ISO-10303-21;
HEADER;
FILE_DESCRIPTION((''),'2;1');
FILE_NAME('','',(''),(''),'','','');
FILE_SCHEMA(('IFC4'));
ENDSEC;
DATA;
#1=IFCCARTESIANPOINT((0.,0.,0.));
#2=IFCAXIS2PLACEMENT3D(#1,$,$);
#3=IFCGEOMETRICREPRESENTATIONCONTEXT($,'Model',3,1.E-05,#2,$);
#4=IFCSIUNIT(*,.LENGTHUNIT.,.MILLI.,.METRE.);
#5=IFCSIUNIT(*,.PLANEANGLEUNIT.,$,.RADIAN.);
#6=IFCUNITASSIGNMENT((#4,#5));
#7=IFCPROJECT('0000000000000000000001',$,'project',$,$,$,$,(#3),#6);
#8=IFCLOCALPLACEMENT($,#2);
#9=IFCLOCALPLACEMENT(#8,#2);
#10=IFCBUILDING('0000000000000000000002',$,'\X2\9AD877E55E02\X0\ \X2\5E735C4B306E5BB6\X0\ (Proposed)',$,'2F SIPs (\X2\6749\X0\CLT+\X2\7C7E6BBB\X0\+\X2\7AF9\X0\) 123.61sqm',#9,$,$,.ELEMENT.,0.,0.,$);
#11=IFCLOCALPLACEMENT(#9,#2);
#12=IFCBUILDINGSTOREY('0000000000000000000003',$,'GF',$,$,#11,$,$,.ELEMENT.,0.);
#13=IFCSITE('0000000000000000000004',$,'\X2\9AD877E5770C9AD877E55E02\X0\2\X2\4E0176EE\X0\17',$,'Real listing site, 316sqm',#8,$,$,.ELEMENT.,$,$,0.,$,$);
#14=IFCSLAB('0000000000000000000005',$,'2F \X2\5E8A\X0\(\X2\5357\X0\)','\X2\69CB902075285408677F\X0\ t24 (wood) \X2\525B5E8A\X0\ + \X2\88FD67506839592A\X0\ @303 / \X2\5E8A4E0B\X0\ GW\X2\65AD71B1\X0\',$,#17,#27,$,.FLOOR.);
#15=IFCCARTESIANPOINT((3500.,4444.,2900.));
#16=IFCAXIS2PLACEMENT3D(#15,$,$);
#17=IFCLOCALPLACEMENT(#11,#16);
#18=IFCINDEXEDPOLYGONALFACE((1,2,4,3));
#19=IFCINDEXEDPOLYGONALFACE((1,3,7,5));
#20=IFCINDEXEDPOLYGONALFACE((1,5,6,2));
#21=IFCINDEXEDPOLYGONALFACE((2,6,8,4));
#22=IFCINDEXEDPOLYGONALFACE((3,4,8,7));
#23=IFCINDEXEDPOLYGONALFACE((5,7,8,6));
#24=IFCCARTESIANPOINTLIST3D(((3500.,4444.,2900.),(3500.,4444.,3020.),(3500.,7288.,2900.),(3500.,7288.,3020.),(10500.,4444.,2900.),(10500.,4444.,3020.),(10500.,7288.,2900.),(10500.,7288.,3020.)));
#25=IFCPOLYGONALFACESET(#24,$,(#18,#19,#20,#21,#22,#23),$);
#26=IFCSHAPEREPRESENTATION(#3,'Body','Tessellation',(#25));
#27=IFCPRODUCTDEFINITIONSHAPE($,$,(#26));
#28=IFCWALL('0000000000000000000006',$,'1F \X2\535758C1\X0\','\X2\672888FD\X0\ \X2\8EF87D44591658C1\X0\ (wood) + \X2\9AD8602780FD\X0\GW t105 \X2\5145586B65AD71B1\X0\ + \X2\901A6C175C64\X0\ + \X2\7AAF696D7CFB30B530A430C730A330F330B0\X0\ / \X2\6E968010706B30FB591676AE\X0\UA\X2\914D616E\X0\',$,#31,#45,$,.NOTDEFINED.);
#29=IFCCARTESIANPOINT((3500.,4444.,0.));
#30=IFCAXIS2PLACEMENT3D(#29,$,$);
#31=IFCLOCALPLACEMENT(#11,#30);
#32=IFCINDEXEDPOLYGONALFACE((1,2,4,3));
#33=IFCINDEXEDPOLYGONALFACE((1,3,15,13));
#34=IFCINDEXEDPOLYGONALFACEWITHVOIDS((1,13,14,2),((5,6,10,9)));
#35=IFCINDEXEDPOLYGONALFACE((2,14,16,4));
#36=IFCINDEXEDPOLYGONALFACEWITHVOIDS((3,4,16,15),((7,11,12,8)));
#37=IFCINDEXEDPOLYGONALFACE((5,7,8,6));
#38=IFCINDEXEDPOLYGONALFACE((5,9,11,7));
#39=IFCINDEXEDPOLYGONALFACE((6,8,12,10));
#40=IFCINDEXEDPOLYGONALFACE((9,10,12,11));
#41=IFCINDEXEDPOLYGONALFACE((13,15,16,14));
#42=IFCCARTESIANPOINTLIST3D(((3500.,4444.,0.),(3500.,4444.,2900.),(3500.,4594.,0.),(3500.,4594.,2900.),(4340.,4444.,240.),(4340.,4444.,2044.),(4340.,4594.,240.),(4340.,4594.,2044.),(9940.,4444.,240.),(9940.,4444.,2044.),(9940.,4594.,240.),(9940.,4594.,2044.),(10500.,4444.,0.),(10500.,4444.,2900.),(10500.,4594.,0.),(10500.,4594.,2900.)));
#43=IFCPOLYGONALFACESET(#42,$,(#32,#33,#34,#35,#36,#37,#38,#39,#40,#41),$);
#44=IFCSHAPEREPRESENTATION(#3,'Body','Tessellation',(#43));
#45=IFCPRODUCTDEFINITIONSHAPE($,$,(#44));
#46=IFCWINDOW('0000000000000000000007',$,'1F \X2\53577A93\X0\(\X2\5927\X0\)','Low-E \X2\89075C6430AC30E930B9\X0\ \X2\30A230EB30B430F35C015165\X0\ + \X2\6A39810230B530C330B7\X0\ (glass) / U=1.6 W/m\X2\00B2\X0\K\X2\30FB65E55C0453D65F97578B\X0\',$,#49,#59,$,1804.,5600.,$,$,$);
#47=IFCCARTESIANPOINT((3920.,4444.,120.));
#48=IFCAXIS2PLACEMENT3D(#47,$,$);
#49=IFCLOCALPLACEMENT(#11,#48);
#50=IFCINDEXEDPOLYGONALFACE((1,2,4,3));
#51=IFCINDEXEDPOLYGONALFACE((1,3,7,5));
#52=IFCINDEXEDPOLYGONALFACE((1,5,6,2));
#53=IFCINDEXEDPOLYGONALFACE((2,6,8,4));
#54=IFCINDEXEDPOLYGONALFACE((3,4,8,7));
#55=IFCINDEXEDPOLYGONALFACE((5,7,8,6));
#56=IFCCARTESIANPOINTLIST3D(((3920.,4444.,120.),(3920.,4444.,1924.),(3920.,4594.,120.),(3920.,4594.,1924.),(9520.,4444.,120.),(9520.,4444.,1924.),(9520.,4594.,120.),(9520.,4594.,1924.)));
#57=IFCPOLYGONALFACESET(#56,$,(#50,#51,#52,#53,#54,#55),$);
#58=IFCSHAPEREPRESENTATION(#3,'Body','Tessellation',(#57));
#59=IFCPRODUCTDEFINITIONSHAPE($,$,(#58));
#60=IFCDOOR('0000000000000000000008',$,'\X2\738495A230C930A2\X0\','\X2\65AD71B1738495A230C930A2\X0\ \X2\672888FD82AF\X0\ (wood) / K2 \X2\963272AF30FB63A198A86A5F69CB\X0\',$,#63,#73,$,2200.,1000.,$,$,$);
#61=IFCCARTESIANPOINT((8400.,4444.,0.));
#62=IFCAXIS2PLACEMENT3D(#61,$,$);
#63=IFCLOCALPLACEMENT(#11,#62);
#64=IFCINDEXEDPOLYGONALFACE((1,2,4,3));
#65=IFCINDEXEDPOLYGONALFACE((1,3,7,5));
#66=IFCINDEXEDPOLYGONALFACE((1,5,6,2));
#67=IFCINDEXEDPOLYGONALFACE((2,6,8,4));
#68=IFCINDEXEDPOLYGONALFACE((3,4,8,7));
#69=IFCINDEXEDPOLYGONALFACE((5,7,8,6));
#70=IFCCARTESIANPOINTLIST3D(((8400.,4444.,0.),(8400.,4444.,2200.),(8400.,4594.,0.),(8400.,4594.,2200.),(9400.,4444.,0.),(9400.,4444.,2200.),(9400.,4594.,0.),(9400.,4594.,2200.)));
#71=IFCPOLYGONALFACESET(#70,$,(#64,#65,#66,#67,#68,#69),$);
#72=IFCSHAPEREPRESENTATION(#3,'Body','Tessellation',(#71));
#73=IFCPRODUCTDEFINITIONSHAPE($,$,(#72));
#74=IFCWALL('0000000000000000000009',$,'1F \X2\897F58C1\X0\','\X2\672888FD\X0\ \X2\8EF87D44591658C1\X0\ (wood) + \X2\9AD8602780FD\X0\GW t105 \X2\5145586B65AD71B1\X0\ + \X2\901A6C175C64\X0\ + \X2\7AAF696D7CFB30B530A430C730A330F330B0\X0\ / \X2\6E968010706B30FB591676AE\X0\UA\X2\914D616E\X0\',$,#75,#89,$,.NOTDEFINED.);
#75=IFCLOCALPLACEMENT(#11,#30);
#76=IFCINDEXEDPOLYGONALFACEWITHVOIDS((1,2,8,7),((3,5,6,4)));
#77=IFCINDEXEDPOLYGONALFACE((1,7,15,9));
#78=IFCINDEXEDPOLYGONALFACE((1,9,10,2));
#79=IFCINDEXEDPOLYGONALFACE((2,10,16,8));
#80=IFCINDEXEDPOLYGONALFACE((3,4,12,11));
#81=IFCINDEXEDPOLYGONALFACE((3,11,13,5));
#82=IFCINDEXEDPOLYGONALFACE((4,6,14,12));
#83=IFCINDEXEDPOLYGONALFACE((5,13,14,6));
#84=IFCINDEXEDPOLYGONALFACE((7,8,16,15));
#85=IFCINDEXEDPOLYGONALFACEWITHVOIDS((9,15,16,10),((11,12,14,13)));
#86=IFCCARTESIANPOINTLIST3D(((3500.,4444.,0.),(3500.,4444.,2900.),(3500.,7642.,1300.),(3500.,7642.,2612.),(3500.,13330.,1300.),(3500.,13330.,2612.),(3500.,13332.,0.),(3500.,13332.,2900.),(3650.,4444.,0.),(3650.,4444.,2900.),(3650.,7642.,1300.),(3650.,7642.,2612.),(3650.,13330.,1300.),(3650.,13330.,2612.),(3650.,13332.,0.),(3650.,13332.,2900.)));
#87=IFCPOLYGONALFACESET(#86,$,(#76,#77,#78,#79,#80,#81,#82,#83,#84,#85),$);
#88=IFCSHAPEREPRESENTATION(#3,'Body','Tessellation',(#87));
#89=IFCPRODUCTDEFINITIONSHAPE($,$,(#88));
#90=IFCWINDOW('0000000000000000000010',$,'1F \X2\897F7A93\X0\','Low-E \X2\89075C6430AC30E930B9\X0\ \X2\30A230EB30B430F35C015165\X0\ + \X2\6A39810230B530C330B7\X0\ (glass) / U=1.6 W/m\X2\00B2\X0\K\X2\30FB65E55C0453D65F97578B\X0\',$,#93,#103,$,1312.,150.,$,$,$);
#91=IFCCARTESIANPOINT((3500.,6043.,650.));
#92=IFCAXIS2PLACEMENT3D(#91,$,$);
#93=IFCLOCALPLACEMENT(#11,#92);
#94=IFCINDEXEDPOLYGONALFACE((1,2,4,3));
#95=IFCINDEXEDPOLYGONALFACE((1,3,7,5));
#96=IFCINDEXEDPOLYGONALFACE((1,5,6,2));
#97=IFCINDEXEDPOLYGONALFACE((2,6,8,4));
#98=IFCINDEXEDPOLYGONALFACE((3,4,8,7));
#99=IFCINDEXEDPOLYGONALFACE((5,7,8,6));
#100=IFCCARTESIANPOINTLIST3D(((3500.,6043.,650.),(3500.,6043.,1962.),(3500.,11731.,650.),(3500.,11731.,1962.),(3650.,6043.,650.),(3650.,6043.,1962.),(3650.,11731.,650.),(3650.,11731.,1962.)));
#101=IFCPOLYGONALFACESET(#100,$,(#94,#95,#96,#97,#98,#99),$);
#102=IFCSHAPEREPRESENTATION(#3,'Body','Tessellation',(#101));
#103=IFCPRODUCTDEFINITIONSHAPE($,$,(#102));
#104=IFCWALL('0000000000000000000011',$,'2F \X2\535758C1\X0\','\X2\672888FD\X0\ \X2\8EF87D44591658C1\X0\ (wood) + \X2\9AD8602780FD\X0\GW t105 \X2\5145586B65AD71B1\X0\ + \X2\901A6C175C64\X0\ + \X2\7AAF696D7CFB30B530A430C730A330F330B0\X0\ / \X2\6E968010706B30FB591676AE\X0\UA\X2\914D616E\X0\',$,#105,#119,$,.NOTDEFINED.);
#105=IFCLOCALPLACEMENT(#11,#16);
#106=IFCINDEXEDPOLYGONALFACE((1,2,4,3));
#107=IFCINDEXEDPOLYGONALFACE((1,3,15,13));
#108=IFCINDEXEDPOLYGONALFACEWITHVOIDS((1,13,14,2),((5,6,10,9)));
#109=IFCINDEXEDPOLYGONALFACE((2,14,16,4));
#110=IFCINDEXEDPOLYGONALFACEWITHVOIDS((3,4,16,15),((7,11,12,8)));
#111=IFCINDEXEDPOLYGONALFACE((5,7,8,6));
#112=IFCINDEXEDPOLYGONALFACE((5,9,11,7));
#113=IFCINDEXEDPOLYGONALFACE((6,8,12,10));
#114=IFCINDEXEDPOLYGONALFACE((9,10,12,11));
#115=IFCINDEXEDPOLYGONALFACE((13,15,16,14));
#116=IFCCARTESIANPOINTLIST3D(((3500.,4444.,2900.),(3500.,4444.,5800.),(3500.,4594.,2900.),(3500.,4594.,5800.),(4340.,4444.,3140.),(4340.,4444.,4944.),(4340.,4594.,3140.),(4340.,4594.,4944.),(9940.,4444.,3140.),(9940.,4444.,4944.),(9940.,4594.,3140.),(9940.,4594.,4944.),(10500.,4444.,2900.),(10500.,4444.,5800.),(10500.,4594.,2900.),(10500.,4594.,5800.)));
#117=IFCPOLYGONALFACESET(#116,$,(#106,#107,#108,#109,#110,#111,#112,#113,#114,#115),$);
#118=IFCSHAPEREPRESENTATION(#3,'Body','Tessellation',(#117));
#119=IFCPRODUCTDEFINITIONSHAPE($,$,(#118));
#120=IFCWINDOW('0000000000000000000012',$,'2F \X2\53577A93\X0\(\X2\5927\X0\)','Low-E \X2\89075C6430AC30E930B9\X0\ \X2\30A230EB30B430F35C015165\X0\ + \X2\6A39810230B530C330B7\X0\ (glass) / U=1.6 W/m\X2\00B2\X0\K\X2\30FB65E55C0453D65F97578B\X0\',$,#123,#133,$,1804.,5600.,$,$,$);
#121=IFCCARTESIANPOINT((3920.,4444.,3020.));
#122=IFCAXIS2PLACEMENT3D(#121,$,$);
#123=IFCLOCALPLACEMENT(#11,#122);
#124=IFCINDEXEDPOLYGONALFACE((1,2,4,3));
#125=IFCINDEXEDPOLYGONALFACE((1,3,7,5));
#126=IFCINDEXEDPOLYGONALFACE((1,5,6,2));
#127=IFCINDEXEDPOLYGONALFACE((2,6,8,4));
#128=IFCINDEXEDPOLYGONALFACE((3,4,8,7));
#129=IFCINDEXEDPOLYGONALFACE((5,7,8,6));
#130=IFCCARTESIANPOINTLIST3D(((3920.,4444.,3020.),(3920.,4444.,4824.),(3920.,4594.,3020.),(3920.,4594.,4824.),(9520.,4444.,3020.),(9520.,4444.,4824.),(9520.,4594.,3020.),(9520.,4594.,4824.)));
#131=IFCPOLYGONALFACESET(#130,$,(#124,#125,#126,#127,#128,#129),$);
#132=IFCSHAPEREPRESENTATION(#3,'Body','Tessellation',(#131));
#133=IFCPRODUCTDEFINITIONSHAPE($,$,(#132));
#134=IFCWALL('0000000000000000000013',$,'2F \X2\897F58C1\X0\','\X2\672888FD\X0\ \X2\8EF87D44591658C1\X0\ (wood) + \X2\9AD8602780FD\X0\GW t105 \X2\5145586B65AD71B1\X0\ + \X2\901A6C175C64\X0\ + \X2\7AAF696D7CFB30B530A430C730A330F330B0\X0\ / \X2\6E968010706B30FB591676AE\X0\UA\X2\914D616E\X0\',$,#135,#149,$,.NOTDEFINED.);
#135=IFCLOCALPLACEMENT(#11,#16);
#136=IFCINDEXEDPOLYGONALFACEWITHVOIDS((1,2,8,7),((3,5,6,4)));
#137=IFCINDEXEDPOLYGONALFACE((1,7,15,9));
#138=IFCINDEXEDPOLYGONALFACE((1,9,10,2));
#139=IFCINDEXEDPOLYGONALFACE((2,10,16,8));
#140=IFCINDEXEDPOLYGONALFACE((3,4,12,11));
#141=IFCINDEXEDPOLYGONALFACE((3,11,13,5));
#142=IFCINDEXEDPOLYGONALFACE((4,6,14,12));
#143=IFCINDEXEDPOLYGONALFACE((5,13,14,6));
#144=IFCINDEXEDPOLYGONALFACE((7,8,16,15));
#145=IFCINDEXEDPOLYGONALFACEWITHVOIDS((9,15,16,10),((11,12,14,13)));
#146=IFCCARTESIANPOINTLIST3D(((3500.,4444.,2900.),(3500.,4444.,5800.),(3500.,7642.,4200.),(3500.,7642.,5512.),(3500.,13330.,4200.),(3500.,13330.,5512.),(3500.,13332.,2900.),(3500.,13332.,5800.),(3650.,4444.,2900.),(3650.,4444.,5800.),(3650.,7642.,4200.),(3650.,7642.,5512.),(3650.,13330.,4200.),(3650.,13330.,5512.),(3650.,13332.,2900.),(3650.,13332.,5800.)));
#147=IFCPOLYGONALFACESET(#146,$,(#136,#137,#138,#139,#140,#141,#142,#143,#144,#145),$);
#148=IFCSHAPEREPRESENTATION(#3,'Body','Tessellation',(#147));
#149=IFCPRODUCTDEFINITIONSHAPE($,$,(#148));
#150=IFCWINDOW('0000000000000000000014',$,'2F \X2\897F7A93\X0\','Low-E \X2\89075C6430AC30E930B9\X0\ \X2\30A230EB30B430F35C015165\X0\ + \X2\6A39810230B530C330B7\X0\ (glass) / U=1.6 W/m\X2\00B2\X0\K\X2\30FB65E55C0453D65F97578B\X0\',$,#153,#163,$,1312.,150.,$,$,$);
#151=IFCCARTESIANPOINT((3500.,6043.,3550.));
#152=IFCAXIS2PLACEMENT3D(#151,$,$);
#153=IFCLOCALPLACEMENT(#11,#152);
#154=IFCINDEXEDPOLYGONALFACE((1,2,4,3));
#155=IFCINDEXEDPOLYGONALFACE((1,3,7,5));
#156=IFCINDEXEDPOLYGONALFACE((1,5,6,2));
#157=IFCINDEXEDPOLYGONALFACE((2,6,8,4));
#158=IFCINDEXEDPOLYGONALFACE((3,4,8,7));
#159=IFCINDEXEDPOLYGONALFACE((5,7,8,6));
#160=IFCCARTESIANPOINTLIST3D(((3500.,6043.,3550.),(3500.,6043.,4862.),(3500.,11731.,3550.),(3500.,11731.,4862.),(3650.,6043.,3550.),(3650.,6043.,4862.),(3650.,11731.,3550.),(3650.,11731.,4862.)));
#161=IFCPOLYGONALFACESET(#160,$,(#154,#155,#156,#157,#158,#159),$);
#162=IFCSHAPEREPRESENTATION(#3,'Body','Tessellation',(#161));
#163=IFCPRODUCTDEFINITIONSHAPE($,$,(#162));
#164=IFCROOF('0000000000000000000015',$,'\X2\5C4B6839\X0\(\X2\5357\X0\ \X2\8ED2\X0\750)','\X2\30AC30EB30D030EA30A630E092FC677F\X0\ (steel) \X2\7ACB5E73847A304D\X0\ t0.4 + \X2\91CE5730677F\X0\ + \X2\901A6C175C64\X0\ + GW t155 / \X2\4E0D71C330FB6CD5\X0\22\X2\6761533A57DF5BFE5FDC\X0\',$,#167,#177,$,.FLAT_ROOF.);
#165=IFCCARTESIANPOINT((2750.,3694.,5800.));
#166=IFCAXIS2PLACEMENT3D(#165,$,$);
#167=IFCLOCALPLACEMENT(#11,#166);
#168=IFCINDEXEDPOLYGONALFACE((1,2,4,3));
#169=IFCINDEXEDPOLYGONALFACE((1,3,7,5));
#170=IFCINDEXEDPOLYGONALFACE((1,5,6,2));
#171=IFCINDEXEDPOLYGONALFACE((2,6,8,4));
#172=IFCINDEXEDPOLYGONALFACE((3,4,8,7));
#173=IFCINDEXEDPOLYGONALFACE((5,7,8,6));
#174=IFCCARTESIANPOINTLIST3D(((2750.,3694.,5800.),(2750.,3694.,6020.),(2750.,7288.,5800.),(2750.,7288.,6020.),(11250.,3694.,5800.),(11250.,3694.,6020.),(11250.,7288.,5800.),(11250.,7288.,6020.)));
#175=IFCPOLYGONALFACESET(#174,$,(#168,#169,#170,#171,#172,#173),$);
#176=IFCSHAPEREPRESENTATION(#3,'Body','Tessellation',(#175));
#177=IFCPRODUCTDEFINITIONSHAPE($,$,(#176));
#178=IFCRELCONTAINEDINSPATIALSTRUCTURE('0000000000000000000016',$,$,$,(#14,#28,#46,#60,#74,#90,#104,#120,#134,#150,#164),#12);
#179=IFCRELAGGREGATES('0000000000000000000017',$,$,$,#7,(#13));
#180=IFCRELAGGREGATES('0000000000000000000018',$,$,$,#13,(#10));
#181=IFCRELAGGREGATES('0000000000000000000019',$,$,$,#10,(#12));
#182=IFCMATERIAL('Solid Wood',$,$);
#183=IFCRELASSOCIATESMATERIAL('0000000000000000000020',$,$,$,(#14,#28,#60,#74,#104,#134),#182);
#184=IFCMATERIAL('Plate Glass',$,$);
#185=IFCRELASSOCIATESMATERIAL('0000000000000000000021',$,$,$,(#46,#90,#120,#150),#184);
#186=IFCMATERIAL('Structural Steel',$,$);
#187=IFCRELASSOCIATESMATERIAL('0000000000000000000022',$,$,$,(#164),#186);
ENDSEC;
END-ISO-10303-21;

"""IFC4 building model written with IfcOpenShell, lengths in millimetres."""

from ifc_helpers import new_model, si_unit, frame, frame_2d, origin, place, context, project, spatial, rectangle, extrude, material, element, fill, save


model = new_model("IFC4")

# Units and contexts
model_context = context("Model", 3, precision=1e-05, world=origin())
ifc_project = project(units=[si_unit("LENGTHUNIT", "METRE", prefix="MILLI"), si_unit("PLANEANGLEUNIT", "RADIAN")], contexts=[model_context])

# Site, building, storey
site_placement = place(None, origin())
site = spatial("IfcSite", under=ifc_project, at=site_placement, Name="高知県高知市2丁目17", ObjectType="Real listing site, 316sqm", CompositionType="ELEMENT", RefElevation=0.0)
building_placement = place(site_placement, origin())
building = spatial("IfcBuilding", under=site, at=building_placement, Name="高知市 平屋の家 (Proposed)", ObjectType="2F SIPs (杉CLT+籾殻+竹) 123.61sqm", CompositionType="ELEMENT", ElevationOfRefHeight=0.0, ElevationOfTerrain=0.0)
storey_placement = place(building_placement, origin())
storey = spatial("IfcBuildingStorey", under=building, at=storey_placement, Name="GF", CompositionType="ELEMENT", Elevation=0.0)

# Slab
ifc_material_1 = material(Name="Solid Wood")
slab_1_placement = place(storey_placement, frame((3500.0, 4444.0, 2900.0)))
element("IfcSlab", 1, at=slab_1_placement, inside=storey, material=ifc_material_1, Name="2F 床(南)", Description="構造用合板 t24 (wood) 剛床 + 製材根太 @303 / 床下 GW断熱", PredefinedType="FLOOR", context=model_context, shape_type="SweptSolid", body=[
    extrude(rectangle(XDim=7000.0, YDim=2844.0, at=frame_2d((3500.0, 1422.0))), frame((3500.0, 4444.0, 2900.0)), (0.0, 0.0, 1.0), 120.0),
])

# Wall, openings, window, door
wall_1_placement = place(storey_placement, frame((3500.0, 4444.0, 0.0)))
wall_1 = element("IfcWall", 2, at=wall_1_placement, inside=storey, material=ifc_material_1, Name="1F 南壁", Description="木製 軸組外壁 (wood) + 高性能GW t105 充填断熱 + 通気層 + 窯業系サイディング / 準耐火・外皮UA配慮", PredefinedType="NOTDEFINED", context=model_context, shape_type="SweptSolid", body=[
    extrude(rectangle(XDim=7000.0, YDim=150.0, at=frame_2d((3500.0, 75.0))), frame((3500.0, 4444.0, 0.0)), (0.0, 0.0, 1.0), 2900.0),
])
opening_1_placement = place(storey_placement, frame((3920.0, 4444.0, 120.0)))
opening_1 = element("IfcOpeningElement", 3, at=opening_1_placement, cuts=wall_1, PredefinedType="NOTDEFINED", context=model_context, shape_type="SweptSolid", body=[
    extrude(rectangle(XDim=5600.0, YDim=150.0, at=frame_2d((2800.0, 75.0))), frame((3920.0, 4444.0, 120.0)), (0.0, 0.0, 1.0), 1804.0),
])
opening_2_placement = place(storey_placement, frame((8400.0, 4444.0, 0.0)))
opening_2 = element("IfcOpeningElement", 4, at=opening_2_placement, cuts=wall_1, PredefinedType="NOTDEFINED", context=model_context, shape_type="SweptSolid", body=[
    extrude(rectangle(XDim=1000.0, YDim=150.0, at=frame_2d((500.0, 75.0))), frame((8400.0, 4444.0, 0.0)), (0.0, 0.0, 1.0), 2200.0),
])
ifc_material_2 = material(Name="Plate Glass")
window_1_placement = place(storey_placement, frame((3920.0, 4444.0, 120.0)))
window_1 = element("IfcWindow", 5, at=window_1_placement, inside=storey, material=ifc_material_2, Name="1F 南窓(大)", Description="Low-E 複層ガラス アルゴン封入 + 樹脂サッシ (glass) / U=1.6 W/m²K・日射取得型", OverallHeight=1804.0, OverallWidth=5600.0, context=model_context, shape_type="SweptSolid", body=[
    extrude(rectangle(XDim=5600.0, YDim=150.0, at=frame_2d((2800.0, 75.0))), frame((3920.0, 4444.0, 120.0)), (0.0, 0.0, 1.0), 1804.0),
])
fill(opening_1, window_1)
door_placement = place(storey_placement, frame((8400.0, 4444.0, 0.0)))
door = element("IfcDoor", 6, at=door_placement, inside=storey, material=ifc_material_1, Name="玄関ドア", Description="断熱玄関ドア 木製芯 (wood) / K2 防犯・採風機構", OverallHeight=2200.0, OverallWidth=1000.0, context=model_context, shape_type="SweptSolid", body=[
    extrude(rectangle(XDim=1000.0, YDim=150.0, at=frame_2d((500.0, 75.0))), frame((8400.0, 4444.0, 0.0)), (0.0, 0.0, 1.0), 2200.0),
])
fill(opening_2, door)

# Walls, openings, windows
wall_2_placement = place(storey_placement, frame((3500.0, 4444.0, 0.0)))
wall_2 = element("IfcWall", 7, at=wall_2_placement, inside=storey, material=ifc_material_1, Name="1F 西壁", Description="木製 軸組外壁 (wood) + 高性能GW t105 充填断熱 + 通気層 + 窯業系サイディング / 準耐火・外皮UA配慮", PredefinedType="NOTDEFINED", context=model_context, shape_type="SweptSolid", body=[
    extrude(rectangle(XDim=150.0, YDim=8888.0, at=frame_2d((75.0, 4444.0))), frame((3500.0, 4444.0, 0.0)), (0.0, 0.0, 1.0), 2900.0),
])
opening_3_placement = place(storey_placement, frame((3500.0, 6043.0, 650.0)))
opening_3 = element("IfcOpeningElement", 8, at=opening_3_placement, cuts=wall_2, PredefinedType="NOTDEFINED", context=model_context, shape_type="SweptSolid", body=[
    extrude(rectangle(XDim=150.0, YDim=5688.0, at=frame_2d((75.0, 2844.0))), frame((3500.0, 6043.0, 650.0)), (0.0, 0.0, 1.0), 1312.0),
])
window_2_placement = place(storey_placement, frame((3500.0, 6043.0, 650.0)))
window_2 = element("IfcWindow", 9, at=window_2_placement, inside=storey, material=ifc_material_2, Name="1F 西窓", Description="Low-E 複層ガラス アルゴン封入 + 樹脂サッシ (glass) / U=1.6 W/m²K・日射取得型", OverallHeight=1312.0, OverallWidth=150.0, context=model_context, shape_type="SweptSolid", body=[
    extrude(rectangle(XDim=150.0, YDim=5688.0, at=frame_2d((75.0, 2844.0))), frame((3500.0, 6043.0, 650.0)), (0.0, 0.0, 1.0), 1312.0),
])
fill(opening_3, window_2)
wall_3_placement = place(storey_placement, frame((3500.0, 4444.0, 2900.0)))
wall_3 = element("IfcWall", 10, at=wall_3_placement, inside=storey, material=ifc_material_1, Name="2F 南壁", Description="木製 軸組外壁 (wood) + 高性能GW t105 充填断熱 + 通気層 + 窯業系サイディング / 準耐火・外皮UA配慮", PredefinedType="NOTDEFINED", context=model_context, shape_type="SweptSolid", body=[
    extrude(rectangle(XDim=7000.0, YDim=150.0, at=frame_2d((3500.0, 75.0))), frame((3500.0, 4444.0, 2900.0)), (0.0, 0.0, 1.0), 2900.0),
])
opening_4_placement = place(storey_placement, frame((3920.0, 4444.0, 3020.0)))
opening_4 = element("IfcOpeningElement", 11, at=opening_4_placement, cuts=wall_3, PredefinedType="NOTDEFINED", context=model_context, shape_type="SweptSolid", body=[
    extrude(rectangle(XDim=5600.0, YDim=150.0, at=frame_2d((2800.0, 75.0))), frame((3920.0, 4444.0, 3020.0)), (0.0, 0.0, 1.0), 1804.0),
])
window_3_placement = place(storey_placement, frame((3920.0, 4444.0, 3020.0)))
window_3 = element("IfcWindow", 12, at=window_3_placement, inside=storey, material=ifc_material_2, Name="2F 南窓(大)", Description="Low-E 複層ガラス アルゴン封入 + 樹脂サッシ (glass) / U=1.6 W/m²K・日射取得型", OverallHeight=1804.0, OverallWidth=5600.0, context=model_context, shape_type="SweptSolid", body=[
    extrude(rectangle(XDim=5600.0, YDim=150.0, at=frame_2d((2800.0, 75.0))), frame((3920.0, 4444.0, 3020.0)), (0.0, 0.0, 1.0), 1804.0),
])
fill(opening_4, window_3)
wall_4_placement = place(storey_placement, frame((3500.0, 4444.0, 2900.0)))
wall_4 = element("IfcWall", 13, at=wall_4_placement, inside=storey, material=ifc_material_1, Name="2F 西壁", Description="木製 軸組外壁 (wood) + 高性能GW t105 充填断熱 + 通気層 + 窯業系サイディング / 準耐火・外皮UA配慮", PredefinedType="NOTDEFINED", context=model_context, shape_type="SweptSolid", body=[
    extrude(rectangle(XDim=150.0, YDim=8888.0, at=frame_2d((75.0, 4444.0))), frame((3500.0, 4444.0, 2900.0)), (0.0, 0.0, 1.0), 2900.0),
])
opening_5_placement = place(storey_placement, frame((3500.0, 6043.0, 3550.0)))
opening_5 = element("IfcOpeningElement", 14, at=opening_5_placement, cuts=wall_4, PredefinedType="NOTDEFINED", context=model_context, shape_type="SweptSolid", body=[
    extrude(rectangle(XDim=150.0, YDim=5688.0, at=frame_2d((75.0, 2844.0))), frame((3500.0, 6043.0, 3550.0)), (0.0, 0.0, 1.0), 1312.0),
])
window_4_placement = place(storey_placement, frame((3500.0, 6043.0, 3550.0)))
window_4 = element("IfcWindow", 15, at=window_4_placement, inside=storey, material=ifc_material_2, Name="2F 西窓", Description="Low-E 複層ガラス アルゴン封入 + 樹脂サッシ (glass) / U=1.6 W/m²K・日射取得型", OverallHeight=1312.0, OverallWidth=150.0, context=model_context, shape_type="SweptSolid", body=[
    extrude(rectangle(XDim=150.0, YDim=5688.0, at=frame_2d((75.0, 2844.0))), frame((3500.0, 6043.0, 3550.0)), (0.0, 0.0, 1.0), 1312.0),
])
fill(opening_5, window_4)

# Roof
ifc_material_3 = material(Name="Structural Steel")
roof_1_placement = place(storey_placement, frame((2750.0, 3694.0, 5800.0)))
element("IfcRoof", 16, at=roof_1_placement, inside=storey, material=ifc_material_3, Name="屋根(南 軒750)", Description="ガルバリウム鋼板 (steel) 立平葺き t0.4 + 野地板 + 通気層 + GW t155 / 不燃・法22条区域対応", PredefinedType="FLAT_ROOF", context=model_context, shape_type="SweptSolid", body=[
    extrude(rectangle(XDim=8500.0, YDim=3594.0, at=frame_2d((4250.0, 1797.0))), frame((2750.0, 3694.0, 5800.0)), (0.0, 0.0, 1.0), 220.0),
])

save(model, "model.ifc")
